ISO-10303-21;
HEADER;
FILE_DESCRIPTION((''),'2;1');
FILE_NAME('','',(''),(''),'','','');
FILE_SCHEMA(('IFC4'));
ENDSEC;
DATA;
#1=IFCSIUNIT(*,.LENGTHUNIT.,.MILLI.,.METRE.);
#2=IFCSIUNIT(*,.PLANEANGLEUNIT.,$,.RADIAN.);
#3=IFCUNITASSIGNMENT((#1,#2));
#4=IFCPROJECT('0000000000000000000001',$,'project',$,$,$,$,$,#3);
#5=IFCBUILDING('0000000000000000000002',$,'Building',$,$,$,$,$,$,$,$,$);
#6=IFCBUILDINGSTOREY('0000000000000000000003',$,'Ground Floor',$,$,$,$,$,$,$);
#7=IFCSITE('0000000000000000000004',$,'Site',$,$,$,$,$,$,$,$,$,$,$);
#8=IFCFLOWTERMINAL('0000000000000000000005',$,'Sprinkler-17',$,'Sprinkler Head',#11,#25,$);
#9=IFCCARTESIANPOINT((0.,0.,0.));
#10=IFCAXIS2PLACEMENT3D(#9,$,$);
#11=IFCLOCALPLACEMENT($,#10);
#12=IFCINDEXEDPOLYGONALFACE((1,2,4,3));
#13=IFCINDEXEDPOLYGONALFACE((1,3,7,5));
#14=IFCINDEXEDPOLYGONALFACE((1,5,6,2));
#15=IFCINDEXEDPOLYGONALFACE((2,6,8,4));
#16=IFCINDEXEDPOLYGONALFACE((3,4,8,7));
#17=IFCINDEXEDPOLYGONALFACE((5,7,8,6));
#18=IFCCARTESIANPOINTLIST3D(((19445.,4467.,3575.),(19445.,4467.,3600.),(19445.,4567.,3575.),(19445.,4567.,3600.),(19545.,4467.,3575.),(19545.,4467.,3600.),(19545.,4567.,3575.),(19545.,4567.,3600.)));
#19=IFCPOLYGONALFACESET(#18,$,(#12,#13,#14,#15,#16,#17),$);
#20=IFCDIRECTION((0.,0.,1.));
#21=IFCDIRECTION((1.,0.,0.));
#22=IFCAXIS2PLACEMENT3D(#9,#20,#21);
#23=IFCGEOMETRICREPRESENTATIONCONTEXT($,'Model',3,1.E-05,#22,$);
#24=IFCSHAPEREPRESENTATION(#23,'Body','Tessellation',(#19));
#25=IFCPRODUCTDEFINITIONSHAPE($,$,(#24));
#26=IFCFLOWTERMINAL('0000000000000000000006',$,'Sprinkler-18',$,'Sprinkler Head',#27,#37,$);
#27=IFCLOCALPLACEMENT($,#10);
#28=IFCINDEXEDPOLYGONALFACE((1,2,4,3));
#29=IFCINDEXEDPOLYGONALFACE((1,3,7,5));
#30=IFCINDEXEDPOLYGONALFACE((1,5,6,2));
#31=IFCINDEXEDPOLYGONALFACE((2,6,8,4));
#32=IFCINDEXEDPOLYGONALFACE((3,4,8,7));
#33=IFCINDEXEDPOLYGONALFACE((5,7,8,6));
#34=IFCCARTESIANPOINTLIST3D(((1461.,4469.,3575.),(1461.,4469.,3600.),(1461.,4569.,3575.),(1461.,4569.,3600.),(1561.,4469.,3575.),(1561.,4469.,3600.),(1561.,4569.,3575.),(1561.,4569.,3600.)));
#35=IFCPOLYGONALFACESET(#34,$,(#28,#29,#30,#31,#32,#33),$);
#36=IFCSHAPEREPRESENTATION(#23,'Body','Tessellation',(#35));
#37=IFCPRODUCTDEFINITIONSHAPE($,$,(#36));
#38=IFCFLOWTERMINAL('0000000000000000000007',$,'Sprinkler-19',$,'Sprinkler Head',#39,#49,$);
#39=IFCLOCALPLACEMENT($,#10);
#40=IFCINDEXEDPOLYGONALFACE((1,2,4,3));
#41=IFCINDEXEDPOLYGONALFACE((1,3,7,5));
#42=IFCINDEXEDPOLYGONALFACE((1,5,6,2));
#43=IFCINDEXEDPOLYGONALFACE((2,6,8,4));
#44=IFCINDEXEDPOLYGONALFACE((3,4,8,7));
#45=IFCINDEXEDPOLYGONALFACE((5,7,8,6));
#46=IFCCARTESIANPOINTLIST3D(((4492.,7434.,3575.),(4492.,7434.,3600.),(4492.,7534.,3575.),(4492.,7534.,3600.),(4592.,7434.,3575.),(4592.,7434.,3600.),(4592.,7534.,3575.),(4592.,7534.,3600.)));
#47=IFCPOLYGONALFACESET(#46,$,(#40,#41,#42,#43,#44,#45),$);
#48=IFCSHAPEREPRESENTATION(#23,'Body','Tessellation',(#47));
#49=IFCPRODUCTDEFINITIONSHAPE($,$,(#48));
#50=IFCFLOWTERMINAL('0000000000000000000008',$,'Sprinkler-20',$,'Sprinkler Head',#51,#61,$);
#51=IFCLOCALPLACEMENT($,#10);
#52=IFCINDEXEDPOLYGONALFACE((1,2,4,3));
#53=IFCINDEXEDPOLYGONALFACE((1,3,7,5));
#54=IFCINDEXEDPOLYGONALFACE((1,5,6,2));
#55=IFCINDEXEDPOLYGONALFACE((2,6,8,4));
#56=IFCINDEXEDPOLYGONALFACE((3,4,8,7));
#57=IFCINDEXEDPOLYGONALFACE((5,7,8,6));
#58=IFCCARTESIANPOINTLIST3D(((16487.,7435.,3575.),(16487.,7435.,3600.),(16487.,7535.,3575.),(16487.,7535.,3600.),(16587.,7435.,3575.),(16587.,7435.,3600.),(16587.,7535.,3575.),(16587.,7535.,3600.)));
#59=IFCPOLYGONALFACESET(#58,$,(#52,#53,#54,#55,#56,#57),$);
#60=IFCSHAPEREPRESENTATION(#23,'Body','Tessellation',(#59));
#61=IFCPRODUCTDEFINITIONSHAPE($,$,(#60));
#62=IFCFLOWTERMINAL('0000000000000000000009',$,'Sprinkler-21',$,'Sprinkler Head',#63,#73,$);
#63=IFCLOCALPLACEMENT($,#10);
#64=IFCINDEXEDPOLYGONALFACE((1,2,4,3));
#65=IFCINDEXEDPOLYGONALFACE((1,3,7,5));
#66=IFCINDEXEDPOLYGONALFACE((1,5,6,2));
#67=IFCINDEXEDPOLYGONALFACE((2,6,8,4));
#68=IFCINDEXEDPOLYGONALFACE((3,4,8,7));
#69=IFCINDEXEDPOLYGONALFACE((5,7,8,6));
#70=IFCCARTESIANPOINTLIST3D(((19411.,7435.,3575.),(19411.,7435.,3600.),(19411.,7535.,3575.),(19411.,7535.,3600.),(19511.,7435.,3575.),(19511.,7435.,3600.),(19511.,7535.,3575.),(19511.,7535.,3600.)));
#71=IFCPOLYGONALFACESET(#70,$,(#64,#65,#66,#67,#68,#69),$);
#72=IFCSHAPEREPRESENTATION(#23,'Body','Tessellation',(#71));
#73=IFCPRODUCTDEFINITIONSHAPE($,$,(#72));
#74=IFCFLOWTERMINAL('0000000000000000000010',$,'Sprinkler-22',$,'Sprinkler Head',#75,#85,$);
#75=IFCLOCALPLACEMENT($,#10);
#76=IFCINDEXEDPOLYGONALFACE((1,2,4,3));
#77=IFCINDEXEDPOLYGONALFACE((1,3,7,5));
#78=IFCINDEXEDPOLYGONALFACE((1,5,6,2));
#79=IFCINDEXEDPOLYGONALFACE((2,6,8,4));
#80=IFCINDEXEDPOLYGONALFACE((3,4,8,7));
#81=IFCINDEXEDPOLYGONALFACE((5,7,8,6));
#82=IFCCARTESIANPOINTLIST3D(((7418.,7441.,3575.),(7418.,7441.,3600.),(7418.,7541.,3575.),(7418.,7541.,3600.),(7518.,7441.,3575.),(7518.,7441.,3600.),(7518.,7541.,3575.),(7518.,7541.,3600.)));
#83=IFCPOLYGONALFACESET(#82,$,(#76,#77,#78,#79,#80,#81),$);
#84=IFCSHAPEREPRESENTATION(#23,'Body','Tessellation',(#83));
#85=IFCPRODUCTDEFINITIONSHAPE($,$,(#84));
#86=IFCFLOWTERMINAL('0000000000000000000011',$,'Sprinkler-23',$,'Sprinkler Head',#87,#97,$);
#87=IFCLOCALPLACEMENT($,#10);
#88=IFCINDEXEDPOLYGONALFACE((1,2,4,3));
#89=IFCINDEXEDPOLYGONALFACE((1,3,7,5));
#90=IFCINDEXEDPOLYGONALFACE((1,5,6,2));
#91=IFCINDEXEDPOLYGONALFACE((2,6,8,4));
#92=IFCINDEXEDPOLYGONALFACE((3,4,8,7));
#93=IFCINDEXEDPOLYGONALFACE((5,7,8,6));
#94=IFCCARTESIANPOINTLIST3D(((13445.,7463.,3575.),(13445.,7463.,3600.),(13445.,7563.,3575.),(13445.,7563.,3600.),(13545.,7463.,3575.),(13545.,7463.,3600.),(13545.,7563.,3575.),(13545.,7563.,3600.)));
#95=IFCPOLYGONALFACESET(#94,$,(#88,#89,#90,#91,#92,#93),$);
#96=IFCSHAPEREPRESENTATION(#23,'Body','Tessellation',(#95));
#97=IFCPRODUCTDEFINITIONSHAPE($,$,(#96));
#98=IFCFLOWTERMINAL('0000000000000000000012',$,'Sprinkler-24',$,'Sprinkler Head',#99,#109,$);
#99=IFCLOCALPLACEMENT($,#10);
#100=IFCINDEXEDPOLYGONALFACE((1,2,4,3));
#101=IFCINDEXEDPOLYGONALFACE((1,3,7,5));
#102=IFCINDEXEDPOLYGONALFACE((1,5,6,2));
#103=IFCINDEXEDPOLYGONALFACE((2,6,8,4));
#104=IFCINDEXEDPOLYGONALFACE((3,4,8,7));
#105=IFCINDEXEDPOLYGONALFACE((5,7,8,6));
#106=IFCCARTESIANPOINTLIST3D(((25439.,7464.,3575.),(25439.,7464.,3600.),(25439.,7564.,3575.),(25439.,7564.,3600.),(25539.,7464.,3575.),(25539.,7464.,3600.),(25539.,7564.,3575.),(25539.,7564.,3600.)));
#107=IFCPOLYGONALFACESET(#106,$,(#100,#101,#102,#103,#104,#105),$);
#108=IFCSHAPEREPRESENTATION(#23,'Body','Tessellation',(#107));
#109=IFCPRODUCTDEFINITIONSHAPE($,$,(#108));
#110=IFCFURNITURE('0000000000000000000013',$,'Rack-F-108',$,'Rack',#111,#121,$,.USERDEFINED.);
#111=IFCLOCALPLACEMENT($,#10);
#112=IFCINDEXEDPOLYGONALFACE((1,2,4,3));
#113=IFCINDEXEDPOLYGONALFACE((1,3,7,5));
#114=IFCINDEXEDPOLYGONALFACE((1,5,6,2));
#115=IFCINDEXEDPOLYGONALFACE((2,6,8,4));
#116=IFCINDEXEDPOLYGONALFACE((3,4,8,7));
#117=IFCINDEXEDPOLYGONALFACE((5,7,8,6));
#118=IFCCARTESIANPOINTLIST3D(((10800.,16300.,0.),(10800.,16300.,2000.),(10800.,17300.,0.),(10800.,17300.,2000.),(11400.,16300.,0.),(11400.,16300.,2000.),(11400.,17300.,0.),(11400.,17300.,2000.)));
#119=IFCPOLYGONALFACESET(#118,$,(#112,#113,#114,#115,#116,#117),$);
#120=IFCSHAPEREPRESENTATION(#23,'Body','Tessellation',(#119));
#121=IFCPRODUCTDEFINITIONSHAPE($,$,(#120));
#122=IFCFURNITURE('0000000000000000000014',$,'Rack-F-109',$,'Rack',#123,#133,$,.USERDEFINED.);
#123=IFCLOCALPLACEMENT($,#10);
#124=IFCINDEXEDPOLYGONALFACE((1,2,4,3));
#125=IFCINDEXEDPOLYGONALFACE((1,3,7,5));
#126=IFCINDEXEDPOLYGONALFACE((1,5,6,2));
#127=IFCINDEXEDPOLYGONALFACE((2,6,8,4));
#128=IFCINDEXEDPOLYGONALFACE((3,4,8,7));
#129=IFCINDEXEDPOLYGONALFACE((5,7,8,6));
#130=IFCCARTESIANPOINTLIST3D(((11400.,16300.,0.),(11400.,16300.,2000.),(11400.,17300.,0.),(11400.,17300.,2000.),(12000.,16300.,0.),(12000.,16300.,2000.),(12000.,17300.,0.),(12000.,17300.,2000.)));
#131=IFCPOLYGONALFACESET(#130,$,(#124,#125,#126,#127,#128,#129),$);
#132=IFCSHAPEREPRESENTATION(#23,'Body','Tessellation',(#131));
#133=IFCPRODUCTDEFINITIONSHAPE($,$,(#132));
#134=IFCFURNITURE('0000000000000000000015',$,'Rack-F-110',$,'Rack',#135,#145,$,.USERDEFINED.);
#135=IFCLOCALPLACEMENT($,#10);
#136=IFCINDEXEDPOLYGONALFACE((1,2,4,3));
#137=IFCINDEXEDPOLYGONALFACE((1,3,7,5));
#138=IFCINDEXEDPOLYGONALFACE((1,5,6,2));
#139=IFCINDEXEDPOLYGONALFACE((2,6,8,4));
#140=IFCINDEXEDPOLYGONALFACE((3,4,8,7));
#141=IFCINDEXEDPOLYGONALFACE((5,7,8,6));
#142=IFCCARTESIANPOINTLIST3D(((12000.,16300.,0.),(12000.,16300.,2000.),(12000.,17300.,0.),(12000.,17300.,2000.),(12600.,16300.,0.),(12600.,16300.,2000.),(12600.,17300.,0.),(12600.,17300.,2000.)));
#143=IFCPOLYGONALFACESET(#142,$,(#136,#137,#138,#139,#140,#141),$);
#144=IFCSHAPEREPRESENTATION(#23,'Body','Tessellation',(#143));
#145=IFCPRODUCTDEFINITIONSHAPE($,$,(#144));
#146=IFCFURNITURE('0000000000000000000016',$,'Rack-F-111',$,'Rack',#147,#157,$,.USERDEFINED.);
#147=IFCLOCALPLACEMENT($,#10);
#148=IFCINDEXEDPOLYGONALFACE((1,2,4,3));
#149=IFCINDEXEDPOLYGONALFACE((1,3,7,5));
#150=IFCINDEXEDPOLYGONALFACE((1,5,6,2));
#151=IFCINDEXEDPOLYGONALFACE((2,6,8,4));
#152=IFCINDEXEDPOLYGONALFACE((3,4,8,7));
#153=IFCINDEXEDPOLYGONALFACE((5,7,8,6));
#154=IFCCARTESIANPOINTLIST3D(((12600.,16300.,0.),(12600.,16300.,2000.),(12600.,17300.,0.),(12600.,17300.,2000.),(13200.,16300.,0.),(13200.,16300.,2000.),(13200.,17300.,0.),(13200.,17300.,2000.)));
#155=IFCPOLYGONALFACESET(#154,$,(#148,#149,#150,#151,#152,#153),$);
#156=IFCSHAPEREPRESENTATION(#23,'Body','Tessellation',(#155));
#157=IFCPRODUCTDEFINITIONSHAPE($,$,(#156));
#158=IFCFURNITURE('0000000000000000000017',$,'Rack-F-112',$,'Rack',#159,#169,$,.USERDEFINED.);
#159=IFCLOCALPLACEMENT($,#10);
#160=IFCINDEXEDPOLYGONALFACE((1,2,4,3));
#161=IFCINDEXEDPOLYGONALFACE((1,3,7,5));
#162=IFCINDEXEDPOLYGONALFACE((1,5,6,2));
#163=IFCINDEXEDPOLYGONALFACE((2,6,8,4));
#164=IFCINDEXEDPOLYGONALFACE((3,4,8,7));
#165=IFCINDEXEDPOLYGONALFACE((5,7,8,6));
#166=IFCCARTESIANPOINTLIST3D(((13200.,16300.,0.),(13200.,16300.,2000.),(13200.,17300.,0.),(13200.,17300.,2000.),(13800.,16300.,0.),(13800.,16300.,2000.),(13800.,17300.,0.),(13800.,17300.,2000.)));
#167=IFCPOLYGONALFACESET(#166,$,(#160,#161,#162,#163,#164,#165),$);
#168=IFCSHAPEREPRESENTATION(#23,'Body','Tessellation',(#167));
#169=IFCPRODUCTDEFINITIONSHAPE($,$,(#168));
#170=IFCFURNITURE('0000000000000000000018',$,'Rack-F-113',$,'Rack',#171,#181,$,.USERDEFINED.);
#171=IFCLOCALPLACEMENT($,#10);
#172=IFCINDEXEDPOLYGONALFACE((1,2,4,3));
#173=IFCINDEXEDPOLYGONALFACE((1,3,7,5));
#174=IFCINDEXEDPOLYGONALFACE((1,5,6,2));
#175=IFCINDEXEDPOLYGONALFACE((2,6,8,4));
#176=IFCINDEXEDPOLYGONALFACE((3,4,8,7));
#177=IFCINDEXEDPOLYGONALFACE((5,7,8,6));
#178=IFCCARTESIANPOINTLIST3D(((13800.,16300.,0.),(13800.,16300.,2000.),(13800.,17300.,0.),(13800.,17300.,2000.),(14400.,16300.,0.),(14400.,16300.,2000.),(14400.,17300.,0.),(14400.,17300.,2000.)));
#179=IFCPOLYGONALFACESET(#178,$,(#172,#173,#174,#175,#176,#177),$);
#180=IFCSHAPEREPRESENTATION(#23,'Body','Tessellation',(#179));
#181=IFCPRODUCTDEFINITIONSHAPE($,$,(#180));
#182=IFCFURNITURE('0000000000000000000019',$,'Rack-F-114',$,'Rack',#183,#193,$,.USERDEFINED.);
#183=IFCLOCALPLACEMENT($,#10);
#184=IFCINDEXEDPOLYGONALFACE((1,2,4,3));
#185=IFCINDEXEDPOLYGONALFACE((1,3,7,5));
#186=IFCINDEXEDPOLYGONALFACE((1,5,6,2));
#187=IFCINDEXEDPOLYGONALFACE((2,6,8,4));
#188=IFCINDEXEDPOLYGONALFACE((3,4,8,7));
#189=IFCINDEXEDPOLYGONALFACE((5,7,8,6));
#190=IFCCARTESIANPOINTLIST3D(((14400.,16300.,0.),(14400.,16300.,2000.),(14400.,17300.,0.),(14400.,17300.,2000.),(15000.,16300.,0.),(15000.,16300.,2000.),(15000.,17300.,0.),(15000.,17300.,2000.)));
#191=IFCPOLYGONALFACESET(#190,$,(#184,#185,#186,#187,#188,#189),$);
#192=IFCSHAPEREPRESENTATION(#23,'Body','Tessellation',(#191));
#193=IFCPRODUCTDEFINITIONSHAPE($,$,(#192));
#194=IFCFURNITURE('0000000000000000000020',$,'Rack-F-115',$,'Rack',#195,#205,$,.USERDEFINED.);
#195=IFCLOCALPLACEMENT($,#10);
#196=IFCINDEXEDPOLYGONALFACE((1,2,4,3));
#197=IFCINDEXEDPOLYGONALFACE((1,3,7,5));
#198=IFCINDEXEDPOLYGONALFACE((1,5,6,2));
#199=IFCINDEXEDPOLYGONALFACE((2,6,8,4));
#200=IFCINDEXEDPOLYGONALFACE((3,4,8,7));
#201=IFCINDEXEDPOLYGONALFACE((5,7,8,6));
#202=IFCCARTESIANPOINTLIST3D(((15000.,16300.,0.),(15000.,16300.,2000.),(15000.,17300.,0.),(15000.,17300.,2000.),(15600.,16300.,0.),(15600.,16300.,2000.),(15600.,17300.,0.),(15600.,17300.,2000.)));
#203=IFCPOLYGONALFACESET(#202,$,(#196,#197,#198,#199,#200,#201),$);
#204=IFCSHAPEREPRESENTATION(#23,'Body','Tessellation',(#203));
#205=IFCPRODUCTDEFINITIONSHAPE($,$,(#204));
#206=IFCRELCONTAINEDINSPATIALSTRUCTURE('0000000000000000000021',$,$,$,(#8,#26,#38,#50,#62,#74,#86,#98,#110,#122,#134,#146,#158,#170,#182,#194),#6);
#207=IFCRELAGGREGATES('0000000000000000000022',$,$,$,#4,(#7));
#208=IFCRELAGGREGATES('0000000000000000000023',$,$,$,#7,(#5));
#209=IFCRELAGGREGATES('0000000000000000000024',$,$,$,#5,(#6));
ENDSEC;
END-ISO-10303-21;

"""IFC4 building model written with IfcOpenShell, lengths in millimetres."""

from ifc_helpers import new_model, si_unit, frame, origin_with_axes, place, context, project, spatial, rectangle, extrude, element, save


model = new_model("IFC4")

# Units and contexts
model_context = context("Model", 3, precision=1e-05, world=origin_with_axes())
ifc_project = project(units=[si_unit("LENGTHUNIT", "METRE", prefix="MILLI"), si_unit("PLANEANGLEUNIT", "RADIAN")])

# Site, building, storey
site = spatial("IfcSite", under=ifc_project, Name="Site")
building = spatial("IfcBuilding", under=site, Name="Building")
storey = spatial("IfcBuildingStorey", under=building, Name="Ground Floor")

# Flow terminals
flow_terminal_1_placement = place(None, origin_with_axes())
element("IfcFlowTerminal", 1, at=flow_terminal_1_placement, inside=storey, Name="Sprinkler-17", ObjectType="Sprinkler Head", context=model_context, shape_type="SweptSolid", body=[
    extrude(rectangle(XDim=100.0, YDim=100.0), frame((19495.0, 4517.0, 3575.0), z_axis=(0.0, 0.0, 1.0), x_axis=(1.0, 0.0, 0.0)), (0.0, 0.0, 1.0), 25.0),
])
flow_terminal_2_placement = place(None, origin_with_axes())
element("IfcFlowTerminal", 2, at=flow_terminal_2_placement, inside=storey, Name="Sprinkler-18", ObjectType="Sprinkler Head", context=model_context, shape_type="SweptSolid", body=[
    extrude(rectangle(XDim=100.0, YDim=100.0), frame((1511.0, 4519.0, 3575.0), z_axis=(0.0, 0.0, 1.0), x_axis=(1.0, 0.0, 0.0)), (0.0, 0.0, 1.0), 25.0),
])
flow_terminal_3_placement = place(None, origin_with_axes())
element("IfcFlowTerminal", 3, at=flow_terminal_3_placement, inside=storey, Name="Sprinkler-19", ObjectType="Sprinkler Head", context=model_context, shape_type="SweptSolid", body=[
    extrude(rectangle(XDim=100.0, YDim=100.0), frame((4542.0, 7484.0, 3575.0), z_axis=(0.0, 0.0, 1.0), x_axis=(1.0, 0.0, 0.0)), (0.0, 0.0, 1.0), 25.0),
])
flow_terminal_4_placement = place(None, origin_with_axes())
element("IfcFlowTerminal", 4, at=flow_terminal_4_placement, inside=storey, Name="Sprinkler-20", ObjectType="Sprinkler Head", context=model_context, shape_type="SweptSolid", body=[
    extrude(rectangle(XDim=100.0, YDim=100.0), frame((16537.0, 7485.0, 3575.0), z_axis=(0.0, 0.0, 1.0), x_axis=(1.0, 0.0, 0.0)), (0.0, 0.0, 1.0), 25.0),
])
flow_terminal_5_placement = place(None, origin_with_axes())
element("IfcFlowTerminal", 5, at=flow_terminal_5_placement, inside=storey, Name="Sprinkler-21", ObjectType="Sprinkler Head", context=model_context, shape_type="SweptSolid", body=[
    extrude(rectangle(XDim=100.0, YDim=100.0), frame((19461.0, 7485.0, 3575.0), z_axis=(0.0, 0.0, 1.0), x_axis=(1.0, 0.0, 0.0)), (0.0, 0.0, 1.0), 25.0),
])
flow_terminal_6_placement = place(None, origin_with_axes())
element("IfcFlowTerminal", 6, at=flow_terminal_6_placement, inside=storey, Name="Sprinkler-22", ObjectType="Sprinkler Head", context=model_context, shape_type="SweptSolid", body=[
    extrude(rectangle(XDim=100.0, YDim=100.0), frame((7468.0, 7491.0, 3575.0), z_axis=(0.0, 0.0, 1.0), x_axis=(1.0, 0.0, 0.0)), (0.0, 0.0, 1.0), 25.0),
])
flow_terminal_7_placement = place(None, origin_with_axes())
element("IfcFlowTerminal", 7, at=flow_terminal_7_placement, inside=storey, Name="Sprinkler-23", ObjectType="Sprinkler Head", context=model_context, shape_type="SweptSolid", body=[
    extrude(rectangle(XDim=100.0, YDim=100.0), frame((13495.0, 7513.0, 3575.0), z_axis=(0.0, 0.0, 1.0), x_axis=(1.0, 0.0, 0.0)), (0.0, 0.0, 1.0), 25.0),
])
flow_terminal_8_placement = place(None, origin_with_axes())
element("IfcFlowTerminal", 8, at=flow_terminal_8_placement, inside=storey, Name="Sprinkler-24", ObjectType="Sprinkler Head", context=model_context, shape_type="SweptSolid", body=[
    extrude(rectangle(XDim=100.0, YDim=100.0), frame((25489.0, 7514.0, 3575.0), z_axis=(0.0, 0.0, 1.0), x_axis=(1.0, 0.0, 0.0)), (0.0, 0.0, 1.0), 25.0),
])

# Furniture
furniture_1_placement = place(None, origin_with_axes())
element("IfcFurniture", 9, at=furniture_1_placement, inside=storey, Name="Rack-F-108", ObjectType="Rack", PredefinedType="USERDEFINED", context=model_context, shape_type="SweptSolid", body=[
    extrude(rectangle(XDim=600.0, YDim=1000.0), frame((11100.0, 16800.0, 0.0), z_axis=(0.0, 0.0, 1.0), x_axis=(1.0, 0.0, 0.0)), (0.0, 0.0, 1.0), 2000.0),
])
furniture_2_placement = place(None, origin_with_axes())
element("IfcFurniture", 10, at=furniture_2_placement, inside=storey, Name="Rack-F-109", ObjectType="Rack", PredefinedType="USERDEFINED", context=model_context, shape_type="SweptSolid", body=[
    extrude(rectangle(XDim=600.0, YDim=1000.0), frame((11700.0, 16800.0, 0.0), z_axis=(0.0, 0.0, 1.0), x_axis=(1.0, 0.0, 0.0)), (0.0, 0.0, 1.0), 2000.0),
])
furniture_3_placement = place(None, origin_with_axes())
element("IfcFurniture", 11, at=furniture_3_placement, inside=storey, Name="Rack-F-110", ObjectType="Rack", PredefinedType="USERDEFINED", context=model_context, shape_type="SweptSolid", body=[
    extrude(rectangle(XDim=600.0, YDim=1000.0), frame((12300.0, 16800.0, 0.0), z_axis=(0.0, 0.0, 1.0), x_axis=(1.0, 0.0, 0.0)), (0.0, 0.0, 1.0), 2000.0),
])
furniture_4_placement = place(None, origin_with_axes())
element("IfcFurniture", 12, at=furniture_4_placement, inside=storey, Name="Rack-F-111", ObjectType="Rack", PredefinedType="USERDEFINED", context=model_context, shape_type="SweptSolid", body=[
    extrude(rectangle(XDim=600.0, YDim=1000.0), frame((12900.0, 16800.0, 0.0), z_axis=(0.0, 0.0, 1.0), x_axis=(1.0, 0.0, 0.0)), (0.0, 0.0, 1.0), 2000.0),
])
furniture_5_placement = place(None, origin_with_axes())
element("IfcFurniture", 13, at=furniture_5_placement, inside=storey, Name="Rack-F-112", ObjectType="Rack", PredefinedType="USERDEFINED", context=model_context, shape_type="SweptSolid", body=[
    extrude(rectangle(XDim=600.0, YDim=1000.0), frame((13500.0, 16800.0, 0.0), z_axis=(0.0, 0.0, 1.0), x_axis=(1.0, 0.0, 0.0)), (0.0, 0.0, 1.0), 2000.0),
])
furniture_6_placement = place(None, origin_with_axes())
element("IfcFurniture", 14, at=furniture_6_placement, inside=storey, Name="Rack-F-113", ObjectType="Rack", PredefinedType="USERDEFINED", context=model_context, shape_type="SweptSolid", body=[
    extrude(rectangle(XDim=600.0, YDim=1000.0), frame((14100.0, 16800.0, 0.0), z_axis=(0.0, 0.0, 1.0), x_axis=(1.0, 0.0, 0.0)), (0.0, 0.0, 1.0), 2000.0),
])
furniture_7_placement = place(None, origin_with_axes())
element("IfcFurniture", 15, at=furniture_7_placement, inside=storey, Name="Rack-F-114", ObjectType="Rack", PredefinedType="USERDEFINED", context=model_context, shape_type="SweptSolid", body=[
    extrude(rectangle(XDim=600.0, YDim=1000.0), frame((14700.0, 16800.0, 0.0), z_axis=(0.0, 0.0, 1.0), x_axis=(1.0, 0.0, 0.0)), (0.0, 0.0, 1.0), 2000.0),
])
furniture_8_placement = place(None, origin_with_axes())
element("IfcFurniture", 16, at=furniture_8_placement, inside=storey, Name="Rack-F-115", ObjectType="Rack", PredefinedType="USERDEFINED", context=model_context, shape_type="SweptSolid", body=[
    extrude(rectangle(XDim=600.0, YDim=1000.0), frame((15300.0, 16800.0, 0.0), z_axis=(0.0, 0.0, 1.0), x_axis=(1.0, 0.0, 0.0)), (0.0, 0.0, 1.0), 2000.0),
])

save(model, "model.ifc")
